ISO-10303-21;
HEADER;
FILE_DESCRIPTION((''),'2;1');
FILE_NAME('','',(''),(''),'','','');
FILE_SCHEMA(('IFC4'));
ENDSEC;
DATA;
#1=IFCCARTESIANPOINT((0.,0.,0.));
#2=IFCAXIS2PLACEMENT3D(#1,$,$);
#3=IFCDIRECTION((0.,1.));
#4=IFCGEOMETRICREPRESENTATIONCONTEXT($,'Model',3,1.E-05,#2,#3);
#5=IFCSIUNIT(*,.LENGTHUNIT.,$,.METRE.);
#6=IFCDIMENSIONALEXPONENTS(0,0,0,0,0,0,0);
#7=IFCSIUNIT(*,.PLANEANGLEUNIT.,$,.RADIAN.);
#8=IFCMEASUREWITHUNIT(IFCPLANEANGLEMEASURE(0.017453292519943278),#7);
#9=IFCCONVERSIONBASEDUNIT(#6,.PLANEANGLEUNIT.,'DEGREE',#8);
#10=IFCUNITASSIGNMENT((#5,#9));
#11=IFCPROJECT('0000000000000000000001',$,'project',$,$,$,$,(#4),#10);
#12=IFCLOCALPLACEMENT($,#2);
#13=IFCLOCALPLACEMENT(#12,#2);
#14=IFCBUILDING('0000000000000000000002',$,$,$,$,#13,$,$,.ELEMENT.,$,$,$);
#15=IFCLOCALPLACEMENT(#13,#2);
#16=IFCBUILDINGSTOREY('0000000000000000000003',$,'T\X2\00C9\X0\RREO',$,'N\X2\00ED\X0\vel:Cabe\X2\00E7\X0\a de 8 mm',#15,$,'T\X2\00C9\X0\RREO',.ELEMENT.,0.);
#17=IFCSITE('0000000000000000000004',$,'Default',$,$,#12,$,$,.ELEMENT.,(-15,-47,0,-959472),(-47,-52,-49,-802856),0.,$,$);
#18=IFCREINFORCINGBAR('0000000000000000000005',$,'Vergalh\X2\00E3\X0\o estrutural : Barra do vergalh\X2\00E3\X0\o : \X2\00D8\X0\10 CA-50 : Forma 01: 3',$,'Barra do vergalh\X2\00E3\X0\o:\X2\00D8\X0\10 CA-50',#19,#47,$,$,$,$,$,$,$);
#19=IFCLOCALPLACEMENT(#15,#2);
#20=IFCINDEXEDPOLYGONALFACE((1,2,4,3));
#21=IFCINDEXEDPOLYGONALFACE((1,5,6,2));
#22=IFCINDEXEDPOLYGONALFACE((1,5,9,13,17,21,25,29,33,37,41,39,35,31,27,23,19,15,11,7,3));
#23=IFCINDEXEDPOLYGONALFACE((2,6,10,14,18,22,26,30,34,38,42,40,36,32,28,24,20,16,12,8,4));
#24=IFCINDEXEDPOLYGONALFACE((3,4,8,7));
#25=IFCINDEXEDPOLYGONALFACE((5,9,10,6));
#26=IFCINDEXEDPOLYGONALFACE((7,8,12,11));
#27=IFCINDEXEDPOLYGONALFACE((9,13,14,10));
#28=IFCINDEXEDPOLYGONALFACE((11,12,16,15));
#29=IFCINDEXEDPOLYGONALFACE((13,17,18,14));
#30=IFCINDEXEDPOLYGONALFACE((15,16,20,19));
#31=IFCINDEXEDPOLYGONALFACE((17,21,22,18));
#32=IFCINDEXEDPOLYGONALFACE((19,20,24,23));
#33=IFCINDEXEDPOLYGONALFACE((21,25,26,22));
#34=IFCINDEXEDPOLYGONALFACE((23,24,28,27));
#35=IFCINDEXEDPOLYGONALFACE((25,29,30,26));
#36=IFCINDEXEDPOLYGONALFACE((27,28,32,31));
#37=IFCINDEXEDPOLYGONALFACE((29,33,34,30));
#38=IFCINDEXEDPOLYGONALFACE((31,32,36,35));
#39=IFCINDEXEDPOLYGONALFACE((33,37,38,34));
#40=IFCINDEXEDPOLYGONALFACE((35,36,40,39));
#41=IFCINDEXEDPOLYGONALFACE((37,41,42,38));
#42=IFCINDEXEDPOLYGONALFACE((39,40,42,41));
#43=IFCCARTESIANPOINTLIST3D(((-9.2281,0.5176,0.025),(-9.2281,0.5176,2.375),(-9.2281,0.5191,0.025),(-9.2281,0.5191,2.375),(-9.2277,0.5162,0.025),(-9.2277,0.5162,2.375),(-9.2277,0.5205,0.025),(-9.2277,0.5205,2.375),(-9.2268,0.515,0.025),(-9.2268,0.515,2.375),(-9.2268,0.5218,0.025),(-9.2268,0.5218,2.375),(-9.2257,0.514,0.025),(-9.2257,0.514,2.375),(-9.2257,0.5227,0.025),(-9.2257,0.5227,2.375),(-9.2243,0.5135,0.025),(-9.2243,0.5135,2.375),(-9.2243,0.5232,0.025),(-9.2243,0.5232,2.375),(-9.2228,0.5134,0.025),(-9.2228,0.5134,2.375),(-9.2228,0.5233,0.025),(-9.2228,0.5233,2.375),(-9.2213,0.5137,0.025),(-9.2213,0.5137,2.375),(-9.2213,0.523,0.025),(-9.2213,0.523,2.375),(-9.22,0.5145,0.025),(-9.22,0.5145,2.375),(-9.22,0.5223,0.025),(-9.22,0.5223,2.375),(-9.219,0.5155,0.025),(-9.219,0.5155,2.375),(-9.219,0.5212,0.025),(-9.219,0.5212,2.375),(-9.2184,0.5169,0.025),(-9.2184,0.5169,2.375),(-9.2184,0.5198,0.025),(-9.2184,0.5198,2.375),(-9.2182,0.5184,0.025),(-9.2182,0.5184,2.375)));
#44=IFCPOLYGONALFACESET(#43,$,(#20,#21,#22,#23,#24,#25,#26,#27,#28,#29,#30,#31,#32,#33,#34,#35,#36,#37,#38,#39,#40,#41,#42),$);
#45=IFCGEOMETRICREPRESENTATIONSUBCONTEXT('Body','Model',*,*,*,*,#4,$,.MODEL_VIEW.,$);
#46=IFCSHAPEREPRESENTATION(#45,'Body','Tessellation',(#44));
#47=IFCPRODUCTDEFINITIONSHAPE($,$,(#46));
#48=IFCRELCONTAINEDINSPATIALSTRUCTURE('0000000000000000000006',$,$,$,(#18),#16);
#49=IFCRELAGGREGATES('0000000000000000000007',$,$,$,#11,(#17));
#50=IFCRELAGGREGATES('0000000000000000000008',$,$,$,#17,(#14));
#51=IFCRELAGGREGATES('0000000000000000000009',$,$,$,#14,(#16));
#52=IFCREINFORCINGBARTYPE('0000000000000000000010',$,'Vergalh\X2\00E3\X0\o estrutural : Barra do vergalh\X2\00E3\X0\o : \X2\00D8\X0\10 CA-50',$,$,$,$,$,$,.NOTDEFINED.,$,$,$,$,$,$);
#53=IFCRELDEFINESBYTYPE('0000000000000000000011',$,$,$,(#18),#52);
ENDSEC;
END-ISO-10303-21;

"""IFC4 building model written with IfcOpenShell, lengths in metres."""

from ifc_helpers import new_model, entity, si_unit, converted_unit, direction, origin, place, context, subcontext, project, spatial, type_object, element, save


model = new_model("IFC4")

# Units and contexts
model_context = context("Model", 3, precision=1e-05, world=origin(), true_north=direction((0.0, 1.0)))
body_context = subcontext(model_context, "Body", "Model", "MODEL_VIEW")
ifc_project = project(units=[si_unit("LENGTHUNIT", "METRE"), converted_unit("PLANEANGLEUNIT", "DEGREE", entity("IfcPlaneAngleMeasure", 0.017453292519943278), si_unit("PLANEANGLEUNIT", "RADIAN"), dimensions=[0, 0, 0, 0, 0, 0, 0])], contexts=[model_context])

# Site, building, storey
site_placement = place(None, origin())
site = spatial("IfcSite", under=ifc_project, at=site_placement, Name="Default", CompositionType="ELEMENT", RefLatitude=(-15, -47, 0, -959472), RefLongitude=(-47, -52, -49, -802856), RefElevation=0.0)
building_placement = place(site_placement, origin())
building = spatial("IfcBuilding", under=site, at=building_placement, CompositionType="ELEMENT")
storey_placement = place(building_placement, origin())
storey = spatial("IfcBuildingStorey", under=building, at=storey_placement, Name="TÉRREO", ObjectType="Nível:Cabeça de 8 mm", LongName="TÉRREO", CompositionType="ELEMENT", Elevation=0.0)

# Reinforcing bar
reinforcing_bar_type_1 = type_object("IfcReinforcingBarType", Name="Vergalhão estrutural : Barra do vergalhão : Ø10 CA-50", PredefinedType="NOTDEFINED")
reinforcing_bar_1_placement = place(storey_placement, origin())
element("IfcReinforcingBar", 1, at=reinforcing_bar_1_placement, inside=storey, type_object=reinforcing_bar_type_1, Name="Vergalhão estrutural : Barra do vergalhão : Ø10 CA-50 : Forma 01: 3", ObjectType="Barra do vergalhão:Ø10 CA-50", context=body_context, shape_type="AdvancedSweptSolid", body=[
    entity("IfcSweptDiskSolid", entity("IfcIndexedPolyCurve", entity("IfcCartesianPointList3D", [[-9.2232, 0.5184, 0.025], [-9.2232, 0.5184, 2.375]]), None, False), 0.005, None, 0.0, 1.0),
])

save(model, "model.ifc")
